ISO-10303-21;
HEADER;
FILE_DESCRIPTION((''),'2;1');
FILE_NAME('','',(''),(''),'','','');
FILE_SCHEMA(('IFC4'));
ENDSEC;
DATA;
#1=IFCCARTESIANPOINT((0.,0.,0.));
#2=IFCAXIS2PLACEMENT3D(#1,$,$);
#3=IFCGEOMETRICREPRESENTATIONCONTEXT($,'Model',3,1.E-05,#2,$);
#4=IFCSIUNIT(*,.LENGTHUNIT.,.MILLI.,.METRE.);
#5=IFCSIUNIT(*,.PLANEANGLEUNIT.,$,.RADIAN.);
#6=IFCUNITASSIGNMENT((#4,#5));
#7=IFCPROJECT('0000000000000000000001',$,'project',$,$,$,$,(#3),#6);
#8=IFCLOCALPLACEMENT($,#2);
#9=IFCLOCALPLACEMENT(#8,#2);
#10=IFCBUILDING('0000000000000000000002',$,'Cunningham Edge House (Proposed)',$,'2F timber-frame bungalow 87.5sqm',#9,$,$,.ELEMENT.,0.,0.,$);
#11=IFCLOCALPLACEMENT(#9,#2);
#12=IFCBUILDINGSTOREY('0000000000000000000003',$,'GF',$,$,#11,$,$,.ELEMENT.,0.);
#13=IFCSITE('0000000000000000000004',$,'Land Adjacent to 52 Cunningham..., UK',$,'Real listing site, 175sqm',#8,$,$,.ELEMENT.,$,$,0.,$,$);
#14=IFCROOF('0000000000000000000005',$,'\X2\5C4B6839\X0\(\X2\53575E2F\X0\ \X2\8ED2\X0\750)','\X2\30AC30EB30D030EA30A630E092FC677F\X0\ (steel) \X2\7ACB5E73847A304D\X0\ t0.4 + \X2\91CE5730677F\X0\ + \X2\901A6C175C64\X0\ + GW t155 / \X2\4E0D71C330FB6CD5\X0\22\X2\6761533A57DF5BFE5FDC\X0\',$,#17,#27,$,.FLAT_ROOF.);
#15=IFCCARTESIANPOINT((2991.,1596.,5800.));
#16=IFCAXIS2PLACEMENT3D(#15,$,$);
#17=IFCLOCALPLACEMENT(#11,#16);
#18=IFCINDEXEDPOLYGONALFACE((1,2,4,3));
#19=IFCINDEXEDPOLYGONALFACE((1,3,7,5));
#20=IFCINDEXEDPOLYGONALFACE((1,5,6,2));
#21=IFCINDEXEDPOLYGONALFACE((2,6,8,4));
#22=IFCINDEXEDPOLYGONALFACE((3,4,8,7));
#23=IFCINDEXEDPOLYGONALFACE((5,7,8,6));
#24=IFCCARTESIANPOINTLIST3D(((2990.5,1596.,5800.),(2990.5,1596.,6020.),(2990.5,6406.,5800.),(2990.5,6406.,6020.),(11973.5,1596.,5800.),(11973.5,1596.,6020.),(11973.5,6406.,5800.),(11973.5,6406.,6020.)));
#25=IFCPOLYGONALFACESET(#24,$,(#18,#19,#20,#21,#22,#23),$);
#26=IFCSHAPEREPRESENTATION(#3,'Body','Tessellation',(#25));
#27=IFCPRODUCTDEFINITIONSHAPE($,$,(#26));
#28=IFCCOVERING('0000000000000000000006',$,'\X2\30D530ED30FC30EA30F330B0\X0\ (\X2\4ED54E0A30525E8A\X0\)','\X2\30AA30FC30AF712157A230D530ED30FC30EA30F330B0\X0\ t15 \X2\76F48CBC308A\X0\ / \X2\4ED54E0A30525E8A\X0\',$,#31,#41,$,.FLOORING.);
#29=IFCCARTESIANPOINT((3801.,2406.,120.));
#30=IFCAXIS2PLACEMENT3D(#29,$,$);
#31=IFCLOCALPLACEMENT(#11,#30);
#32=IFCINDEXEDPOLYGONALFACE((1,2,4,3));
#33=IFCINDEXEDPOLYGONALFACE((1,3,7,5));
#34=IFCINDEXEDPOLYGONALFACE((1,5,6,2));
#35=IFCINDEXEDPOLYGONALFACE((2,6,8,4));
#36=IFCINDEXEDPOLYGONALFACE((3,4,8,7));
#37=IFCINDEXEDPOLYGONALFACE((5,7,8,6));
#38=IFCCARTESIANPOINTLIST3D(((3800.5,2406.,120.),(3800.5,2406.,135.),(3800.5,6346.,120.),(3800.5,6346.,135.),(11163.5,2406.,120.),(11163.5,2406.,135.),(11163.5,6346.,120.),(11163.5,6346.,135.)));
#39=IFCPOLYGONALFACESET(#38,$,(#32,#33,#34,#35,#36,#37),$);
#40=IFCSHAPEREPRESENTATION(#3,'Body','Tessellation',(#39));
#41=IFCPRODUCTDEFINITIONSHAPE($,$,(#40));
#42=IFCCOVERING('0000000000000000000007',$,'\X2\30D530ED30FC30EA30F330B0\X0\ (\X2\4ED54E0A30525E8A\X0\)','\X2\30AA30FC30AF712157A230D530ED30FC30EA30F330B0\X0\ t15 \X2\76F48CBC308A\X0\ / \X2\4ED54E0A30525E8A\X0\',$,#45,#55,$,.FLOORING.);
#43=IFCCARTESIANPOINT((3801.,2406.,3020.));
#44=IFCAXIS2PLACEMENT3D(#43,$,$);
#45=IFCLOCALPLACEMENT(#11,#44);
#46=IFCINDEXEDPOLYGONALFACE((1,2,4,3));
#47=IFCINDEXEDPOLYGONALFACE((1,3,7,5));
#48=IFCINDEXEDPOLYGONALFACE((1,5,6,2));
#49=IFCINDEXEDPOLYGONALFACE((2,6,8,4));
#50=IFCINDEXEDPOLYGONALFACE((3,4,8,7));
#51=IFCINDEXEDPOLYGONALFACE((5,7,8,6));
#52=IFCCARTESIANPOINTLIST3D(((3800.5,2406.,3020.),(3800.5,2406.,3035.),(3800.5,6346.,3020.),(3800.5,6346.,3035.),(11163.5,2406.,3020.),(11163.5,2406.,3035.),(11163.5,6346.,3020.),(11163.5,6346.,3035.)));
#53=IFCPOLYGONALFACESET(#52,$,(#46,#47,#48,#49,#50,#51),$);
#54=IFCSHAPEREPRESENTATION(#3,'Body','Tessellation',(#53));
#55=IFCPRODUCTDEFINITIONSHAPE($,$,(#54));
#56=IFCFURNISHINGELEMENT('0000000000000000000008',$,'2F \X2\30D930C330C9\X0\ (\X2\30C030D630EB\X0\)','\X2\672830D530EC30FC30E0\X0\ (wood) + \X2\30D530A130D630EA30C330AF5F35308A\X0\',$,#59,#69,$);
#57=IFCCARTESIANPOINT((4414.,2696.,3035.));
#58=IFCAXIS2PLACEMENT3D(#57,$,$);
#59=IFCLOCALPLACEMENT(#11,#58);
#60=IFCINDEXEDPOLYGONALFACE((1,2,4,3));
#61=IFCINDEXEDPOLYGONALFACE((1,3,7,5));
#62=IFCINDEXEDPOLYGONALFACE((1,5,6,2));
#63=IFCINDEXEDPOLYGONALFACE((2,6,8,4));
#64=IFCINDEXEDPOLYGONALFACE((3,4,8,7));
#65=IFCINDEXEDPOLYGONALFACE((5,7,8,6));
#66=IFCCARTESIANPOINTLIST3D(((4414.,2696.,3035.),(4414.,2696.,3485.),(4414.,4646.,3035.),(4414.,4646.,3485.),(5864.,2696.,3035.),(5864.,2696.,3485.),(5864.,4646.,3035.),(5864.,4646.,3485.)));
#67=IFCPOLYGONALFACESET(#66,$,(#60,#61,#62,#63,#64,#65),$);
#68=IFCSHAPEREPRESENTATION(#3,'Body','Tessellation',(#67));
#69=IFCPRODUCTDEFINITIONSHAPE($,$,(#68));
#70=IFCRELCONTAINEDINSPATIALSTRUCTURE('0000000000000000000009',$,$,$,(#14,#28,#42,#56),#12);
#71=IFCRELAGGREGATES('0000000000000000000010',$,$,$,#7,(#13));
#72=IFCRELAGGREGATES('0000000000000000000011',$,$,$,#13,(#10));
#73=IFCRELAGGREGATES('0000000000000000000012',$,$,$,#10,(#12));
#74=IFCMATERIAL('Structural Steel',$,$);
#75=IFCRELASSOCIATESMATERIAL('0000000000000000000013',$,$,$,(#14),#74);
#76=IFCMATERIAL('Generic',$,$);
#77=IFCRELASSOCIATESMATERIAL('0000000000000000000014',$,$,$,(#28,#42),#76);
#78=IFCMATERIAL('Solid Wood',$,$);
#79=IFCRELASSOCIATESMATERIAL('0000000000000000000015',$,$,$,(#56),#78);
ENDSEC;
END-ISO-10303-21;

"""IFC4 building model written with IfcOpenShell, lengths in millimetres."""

from ifc_helpers import new_model, si_unit, frame, frame_2d, origin, place, context, project, spatial, rectangle, extrude, material, element, save


model = new_model("IFC4")

# Units and contexts
model_context = context("Model", 3, precision=1e-05, world=origin())
ifc_project = project(units=[si_unit("LENGTHUNIT", "METRE", prefix="MILLI"), si_unit("PLANEANGLEUNIT", "RADIAN")], contexts=[model_context])

# Site, building, storey
site_placement = place(None, origin())
site = spatial("IfcSite", under=ifc_project, at=site_placement, Name="Land Adjacent to 52 Cunningham..., UK", ObjectType="Real listing site, 175sqm", CompositionType="ELEMENT", RefElevation=0.0)
building_placement = place(site_placement, origin())
building = spatial("IfcBuilding", under=site, at=building_placement, Name="Cunningham Edge House (Proposed)", ObjectType="2F timber-frame bungalow 87.5sqm", CompositionType="ELEMENT", ElevationOfRefHeight=0.0, ElevationOfTerrain=0.0)
storey_placement = place(building_placement, origin())
storey = spatial("IfcBuildingStorey", under=building, at=storey_placement, Name="GF", CompositionType="ELEMENT", Elevation=0.0)

# Shared definitions
ifc_material_1 = material(Name="Solid Wood")

# Roof
ifc_material_2 = material(Name="Structural Steel")
for number, where, name in (
    (1, (2991.0, 1596.0, 5800.0), "屋根(南帯 軒750)"),
):
    element("IfcRoof", number, at=place(storey_placement, frame(where)), inside=storey, material=ifc_material_2, Name=name, Description="ガルバリウム鋼板 (steel) 立平葺き t0.4 + 野地板 + 通気層 + GW t155 / 不燃・法22条区域対応", PredefinedType="FLAT_ROOF", context=model_context, shape_type="SweptSolid", body=[
        extrude(rectangle(XDim=8983.0, YDim=4810.0, at=frame_2d((4491.0, 2405.0))), frame((2991.0, 1596.0, 5800.0)), (0.0, 0.0, 1.0), 220.0),
    ])

# Coverings
ifc_material_3 = material(Name="Generic")
covering_1_placement = place(storey_placement, frame((3801.0, 2406.0, 120.0)))
element("IfcCovering", 2, at=covering_1_placement, inside=storey, material=ifc_material_3, Name="フローリング (仕上げ床)", Description="オーク無垢フローリング t15 直貼り / 仕上げ床", PredefinedType="FLOORING", context=model_context, shape_type="SweptSolid", body=[
    extrude(rectangle(XDim=7363.0, YDim=3940.0, at=frame_2d((3681.0, 1970.0))), frame((3801.0, 2406.0, 120.0)), (0.0, 0.0, 1.0), 15.0),
])
covering_2_placement = place(storey_placement, frame((3801.0, 2406.0, 3020.0)))
element("IfcCovering", 3, at=covering_2_placement, inside=storey, material=ifc_material_3, Name="フローリング (仕上げ床)", Description="オーク無垢フローリング t15 直貼り / 仕上げ床", PredefinedType="FLOORING", context=model_context, shape_type="SweptSolid", body=[
    extrude(rectangle(XDim=7363.0, YDim=3940.0, at=frame_2d((3681.0, 1970.0))), frame((3801.0, 2406.0, 3020.0)), (0.0, 0.0, 1.0), 15.0),
])

# Furnishing element
furnishing_placement = place(storey_placement, frame((4414.0, 2696.0, 3035.0)))
element("IfcFurnishingElement", 4, at=furnishing_placement, inside=storey, material=ifc_material_1, Name="2F ベッド (ダブル)", Description="木フレーム (wood) + ファブリック張り", context=model_context, shape_type="SweptSolid", body=[
    extrude(rectangle(XDim=1450.0, YDim=1950.0, at=frame_2d((725.0, 975.0))), frame((4414.0, 2696.0, 3035.0)), (0.0, 0.0, 1.0), 450.0),
])

save(model, "model.ifc")
